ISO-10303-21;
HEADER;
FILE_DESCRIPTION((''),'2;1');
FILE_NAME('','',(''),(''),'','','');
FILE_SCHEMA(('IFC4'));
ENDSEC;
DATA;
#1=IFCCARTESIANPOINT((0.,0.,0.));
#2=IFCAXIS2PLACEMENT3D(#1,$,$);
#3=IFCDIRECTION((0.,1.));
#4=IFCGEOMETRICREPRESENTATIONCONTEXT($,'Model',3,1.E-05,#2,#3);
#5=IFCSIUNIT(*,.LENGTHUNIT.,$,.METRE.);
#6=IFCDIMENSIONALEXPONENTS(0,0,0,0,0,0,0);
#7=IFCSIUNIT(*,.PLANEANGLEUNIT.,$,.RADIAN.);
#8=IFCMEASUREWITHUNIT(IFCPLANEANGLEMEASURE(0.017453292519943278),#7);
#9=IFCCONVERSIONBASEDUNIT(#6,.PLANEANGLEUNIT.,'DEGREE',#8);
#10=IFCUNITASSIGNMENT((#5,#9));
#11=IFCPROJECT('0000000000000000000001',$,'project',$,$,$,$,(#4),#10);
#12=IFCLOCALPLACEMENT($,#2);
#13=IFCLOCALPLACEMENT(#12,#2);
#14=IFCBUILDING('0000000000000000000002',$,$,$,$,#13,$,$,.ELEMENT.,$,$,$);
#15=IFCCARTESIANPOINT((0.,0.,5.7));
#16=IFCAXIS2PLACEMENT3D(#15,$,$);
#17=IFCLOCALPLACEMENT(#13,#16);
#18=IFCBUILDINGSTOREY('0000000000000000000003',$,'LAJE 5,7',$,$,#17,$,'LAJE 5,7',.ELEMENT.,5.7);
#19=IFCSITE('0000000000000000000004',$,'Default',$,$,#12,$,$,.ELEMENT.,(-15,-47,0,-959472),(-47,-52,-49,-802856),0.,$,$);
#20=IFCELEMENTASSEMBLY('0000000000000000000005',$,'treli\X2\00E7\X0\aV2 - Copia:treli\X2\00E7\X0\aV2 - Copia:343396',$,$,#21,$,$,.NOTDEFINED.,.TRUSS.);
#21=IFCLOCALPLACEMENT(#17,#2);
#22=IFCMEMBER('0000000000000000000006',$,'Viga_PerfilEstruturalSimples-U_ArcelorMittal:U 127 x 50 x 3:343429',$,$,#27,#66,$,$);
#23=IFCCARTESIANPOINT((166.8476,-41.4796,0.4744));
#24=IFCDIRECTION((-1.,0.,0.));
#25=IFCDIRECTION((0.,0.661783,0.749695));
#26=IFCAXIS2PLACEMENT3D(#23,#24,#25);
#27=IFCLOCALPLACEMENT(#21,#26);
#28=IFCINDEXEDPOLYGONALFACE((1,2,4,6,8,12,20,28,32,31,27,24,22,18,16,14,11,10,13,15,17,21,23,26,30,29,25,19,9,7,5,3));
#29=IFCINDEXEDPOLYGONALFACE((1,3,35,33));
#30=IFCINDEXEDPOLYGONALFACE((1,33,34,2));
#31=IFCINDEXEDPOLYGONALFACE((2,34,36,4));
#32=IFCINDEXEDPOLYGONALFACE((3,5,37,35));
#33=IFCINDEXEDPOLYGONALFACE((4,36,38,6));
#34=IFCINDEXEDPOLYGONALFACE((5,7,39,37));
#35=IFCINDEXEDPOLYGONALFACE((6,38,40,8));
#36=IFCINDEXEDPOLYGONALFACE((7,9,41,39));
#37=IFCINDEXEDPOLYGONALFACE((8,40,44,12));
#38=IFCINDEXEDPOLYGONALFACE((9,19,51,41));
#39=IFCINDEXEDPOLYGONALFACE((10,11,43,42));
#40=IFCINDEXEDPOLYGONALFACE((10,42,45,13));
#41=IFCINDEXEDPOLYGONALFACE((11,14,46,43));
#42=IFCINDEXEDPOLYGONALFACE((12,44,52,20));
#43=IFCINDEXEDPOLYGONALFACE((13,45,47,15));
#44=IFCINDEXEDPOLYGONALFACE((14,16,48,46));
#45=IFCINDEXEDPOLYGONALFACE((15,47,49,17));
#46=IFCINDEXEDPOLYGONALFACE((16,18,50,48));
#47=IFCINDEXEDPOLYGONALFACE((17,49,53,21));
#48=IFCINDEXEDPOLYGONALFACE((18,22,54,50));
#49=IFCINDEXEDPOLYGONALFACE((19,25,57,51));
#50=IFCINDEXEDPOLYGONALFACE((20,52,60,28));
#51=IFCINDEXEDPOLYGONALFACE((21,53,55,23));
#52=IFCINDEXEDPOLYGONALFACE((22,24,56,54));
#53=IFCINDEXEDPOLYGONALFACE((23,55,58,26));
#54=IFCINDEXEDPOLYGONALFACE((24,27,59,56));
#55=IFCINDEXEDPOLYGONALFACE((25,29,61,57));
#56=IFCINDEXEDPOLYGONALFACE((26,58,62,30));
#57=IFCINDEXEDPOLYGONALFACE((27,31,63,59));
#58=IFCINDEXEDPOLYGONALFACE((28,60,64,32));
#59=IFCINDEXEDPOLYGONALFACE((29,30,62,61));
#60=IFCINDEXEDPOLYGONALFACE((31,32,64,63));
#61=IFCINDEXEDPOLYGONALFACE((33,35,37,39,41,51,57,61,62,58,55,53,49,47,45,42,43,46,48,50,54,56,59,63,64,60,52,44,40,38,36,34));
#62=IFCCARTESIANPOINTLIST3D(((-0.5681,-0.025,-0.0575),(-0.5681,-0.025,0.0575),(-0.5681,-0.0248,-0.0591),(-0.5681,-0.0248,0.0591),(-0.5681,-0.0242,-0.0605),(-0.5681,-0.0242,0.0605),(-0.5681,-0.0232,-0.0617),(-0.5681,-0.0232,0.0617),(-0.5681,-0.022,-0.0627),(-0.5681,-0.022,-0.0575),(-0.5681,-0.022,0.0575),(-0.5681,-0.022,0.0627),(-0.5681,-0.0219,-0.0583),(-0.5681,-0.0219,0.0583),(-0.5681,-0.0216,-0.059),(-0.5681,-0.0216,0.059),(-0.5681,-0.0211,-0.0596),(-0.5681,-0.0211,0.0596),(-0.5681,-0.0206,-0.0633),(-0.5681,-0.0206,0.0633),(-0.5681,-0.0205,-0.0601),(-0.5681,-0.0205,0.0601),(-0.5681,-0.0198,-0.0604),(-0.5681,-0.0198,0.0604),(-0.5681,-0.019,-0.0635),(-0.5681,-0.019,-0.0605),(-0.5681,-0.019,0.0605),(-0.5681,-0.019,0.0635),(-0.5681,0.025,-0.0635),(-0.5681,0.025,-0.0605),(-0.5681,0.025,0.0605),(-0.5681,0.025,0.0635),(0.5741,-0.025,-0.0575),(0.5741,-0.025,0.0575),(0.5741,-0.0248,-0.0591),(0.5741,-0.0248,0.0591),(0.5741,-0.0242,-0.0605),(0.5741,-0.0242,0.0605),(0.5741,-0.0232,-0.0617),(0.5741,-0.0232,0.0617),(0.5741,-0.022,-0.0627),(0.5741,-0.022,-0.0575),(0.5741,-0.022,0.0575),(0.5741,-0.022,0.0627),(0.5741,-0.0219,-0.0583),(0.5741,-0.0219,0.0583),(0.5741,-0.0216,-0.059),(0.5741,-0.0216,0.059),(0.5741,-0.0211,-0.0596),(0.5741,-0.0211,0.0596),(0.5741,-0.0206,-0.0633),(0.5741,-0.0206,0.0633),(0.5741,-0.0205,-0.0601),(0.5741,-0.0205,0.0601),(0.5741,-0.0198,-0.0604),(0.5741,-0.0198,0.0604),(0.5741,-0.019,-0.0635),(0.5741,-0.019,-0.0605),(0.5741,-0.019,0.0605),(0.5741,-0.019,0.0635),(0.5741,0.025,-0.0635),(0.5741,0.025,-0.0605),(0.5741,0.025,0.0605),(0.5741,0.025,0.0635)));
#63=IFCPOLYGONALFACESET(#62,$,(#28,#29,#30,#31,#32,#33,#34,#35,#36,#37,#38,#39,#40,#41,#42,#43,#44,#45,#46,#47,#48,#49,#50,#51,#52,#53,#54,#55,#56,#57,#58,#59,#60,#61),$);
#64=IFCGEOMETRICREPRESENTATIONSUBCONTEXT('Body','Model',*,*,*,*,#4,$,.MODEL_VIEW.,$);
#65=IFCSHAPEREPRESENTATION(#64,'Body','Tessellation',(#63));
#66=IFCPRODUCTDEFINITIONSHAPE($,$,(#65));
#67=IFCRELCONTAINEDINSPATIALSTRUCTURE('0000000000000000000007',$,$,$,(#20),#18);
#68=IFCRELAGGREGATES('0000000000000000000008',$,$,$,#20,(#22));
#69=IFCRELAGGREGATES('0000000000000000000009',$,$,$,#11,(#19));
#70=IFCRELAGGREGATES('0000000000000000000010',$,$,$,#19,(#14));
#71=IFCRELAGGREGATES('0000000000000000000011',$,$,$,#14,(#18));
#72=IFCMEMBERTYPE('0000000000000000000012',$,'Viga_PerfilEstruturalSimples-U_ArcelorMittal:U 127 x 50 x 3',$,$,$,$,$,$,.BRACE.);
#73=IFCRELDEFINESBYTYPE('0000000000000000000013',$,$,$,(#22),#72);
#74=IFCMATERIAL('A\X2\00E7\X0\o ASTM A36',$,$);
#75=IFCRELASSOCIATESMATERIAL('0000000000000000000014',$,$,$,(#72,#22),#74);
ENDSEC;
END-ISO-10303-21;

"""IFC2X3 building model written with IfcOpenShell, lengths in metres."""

from ifc_helpers import new_model, entity, si_unit, converted_unit, direction, frame, frame_2d, origin, place, context, subcontext, project, spatial, polyline, circle_curve, parameter, trimmed, segment, composite_curve, outline, extrude, source, transform, mapped, material, type_object, type_shapes, element, aggregate, save


model = new_model("IFC2X3")

# Units and contexts
model_context = context("Model", 3, precision=1e-05, world=origin(), true_north=direction((0.0, 1.0)))
body_context = subcontext(model_context, "Body", "Model", "MODEL_VIEW")
ifc_project = project(units=[si_unit("LENGTHUNIT", "METRE"), converted_unit("PLANEANGLEUNIT", "DEGREE", entity("IfcPlaneAngleMeasure", 0.017453292519943278), si_unit("PLANEANGLEUNIT", "RADIAN"), dimensions=[0, 0, 0, 0, 0, 0, 0])], contexts=[model_context])

# Site, building, storey
site_placement = place(None, origin())
site = spatial("IfcSite", under=ifc_project, at=site_placement, Name="Default", CompositionType="ELEMENT", RefLatitude=(-15, -47, 0, -959472), RefLongitude=(-47, -52, -49, -802856), RefElevation=0.0)
building_placement = place(site_placement, origin())
building = spatial("IfcBuilding", under=site, at=building_placement, CompositionType="ELEMENT")
storey_placement = place(building_placement, frame((0.0, 0.0, 5.7)))
storey = spatial("IfcBuildingStorey", under=building, at=storey_placement, Name="LAJE 5,7", LongName="LAJE 5,7", CompositionType="ELEMENT", Elevation=5.7)

# Element assembly
assembly_1_placement = place(storey_placement, origin())
assembly_1 = element("IfcElementAssembly", 1, at=assembly_1_placement, inside=storey, Name="treliçaV2 - Copia:treliçaV2 - Copia:343396", AssemblyPlace="NOTDEFINED", PredefinedType="TRUSS")
ifc_material = material(Name="Aço ASTM A36")

# Member
member_type_1 = type_object("IfcMemberType", Name="Viga_PerfilEstruturalSimples-U_ArcelorMittal:U 127 x 50 x 3", PredefinedType="BRACE", material=ifc_material)
shared_shape_1 = source(origin(), body_context, "Body", "SweptSolid", [
    extrude(outline(composite_curve([segment(polyline([(-0.0575, -0.0192), (0.0575, -0.0192)]), True, "CONTINUOUS"), segment(trimmed(circle_curve(frame_2d((0.0575, -0.0132), x_axis=(0.0, 1.0)), 0.006), [parameter(180.0)], [parameter(270.0)], True, "PARAMETER"), True, "CONTINUOUS"), segment(polyline([(0.0635, -0.0132), (0.0635, 0.0308)]), True, "CONTINUOUS"), segment(polyline([(0.0635, 0.0308), (0.0605, 0.0308)]), True, "CONTINUOUS"), segment(polyline([(0.0605, 0.0308), (0.0605, -0.0132)]), True, "CONTINUOUS"), segment(trimmed(circle_curve(frame_2d((0.0575, -0.0132), x_axis=(0.0, 1.0)), 0.003), [parameter(180.0)], [parameter(270.0)], True, "PARAMETER"), False, "CONTINUOUS"), segment(polyline([(0.0575, -0.0162), (-0.0575, -0.0162)]), True, "CONTINUOUS"), segment(trimmed(circle_curve(frame_2d((-0.0575, -0.0132), x_axis=(0.0, 1.0)), 0.003), [parameter(90.0)], [parameter(180.0)], True, "PARAMETER"), False, "CONTINUOUS"), segment(polyline([(-0.0605, -0.0132), (-0.0605, 0.0308)]), True, "CONTINUOUS"), segment(polyline([(-0.0605, 0.0308), (-0.0635, 0.0308)]), True, "CONTINUOUS"), segment(polyline([(-0.0635, 0.0308), (-0.0635, -0.0132)]), True, "CONTINUOUS"), segment(trimmed(circle_curve(frame_2d((-0.0575, -0.0132), x_axis=(0.0, 1.0)), 0.006), [parameter(90.0)], [parameter(180.0)], True, "PARAMETER"), True, "CONTINUOUS")], self_intersect=False)), frame((-0.5681, -0.0058, 0.0), z_axis=(1.0, 0.0, 0.0), x_axis=(0.0, 0.0, -1.0)), (0.0, 0.0, 1.0), 1.1422),
])
type_shapes(member_type_1, [shared_shape_1])
member_1_placement = place(assembly_1_placement, frame((166.8476, -41.4796, 0.4744), z_axis=(-1.0, 0.0, 0.0), x_axis=(0.0, 0.661783, 0.749695)))
member_1 = element("IfcMember", 2, at=member_1_placement, type_object=member_type_1, material=ifc_material, Name="Viga_PerfilEstruturalSimples-U_ArcelorMittal:U 127 x 50 x 3:343429", context=body_context, shape_type="MappedRepresentation", body=[
    mapped(shared_shape_1, transform((0.0, 0.0, 0.0), scale=1.0)),
])
aggregate(assembly_1, [member_1])

save(model, "model.ifc")
